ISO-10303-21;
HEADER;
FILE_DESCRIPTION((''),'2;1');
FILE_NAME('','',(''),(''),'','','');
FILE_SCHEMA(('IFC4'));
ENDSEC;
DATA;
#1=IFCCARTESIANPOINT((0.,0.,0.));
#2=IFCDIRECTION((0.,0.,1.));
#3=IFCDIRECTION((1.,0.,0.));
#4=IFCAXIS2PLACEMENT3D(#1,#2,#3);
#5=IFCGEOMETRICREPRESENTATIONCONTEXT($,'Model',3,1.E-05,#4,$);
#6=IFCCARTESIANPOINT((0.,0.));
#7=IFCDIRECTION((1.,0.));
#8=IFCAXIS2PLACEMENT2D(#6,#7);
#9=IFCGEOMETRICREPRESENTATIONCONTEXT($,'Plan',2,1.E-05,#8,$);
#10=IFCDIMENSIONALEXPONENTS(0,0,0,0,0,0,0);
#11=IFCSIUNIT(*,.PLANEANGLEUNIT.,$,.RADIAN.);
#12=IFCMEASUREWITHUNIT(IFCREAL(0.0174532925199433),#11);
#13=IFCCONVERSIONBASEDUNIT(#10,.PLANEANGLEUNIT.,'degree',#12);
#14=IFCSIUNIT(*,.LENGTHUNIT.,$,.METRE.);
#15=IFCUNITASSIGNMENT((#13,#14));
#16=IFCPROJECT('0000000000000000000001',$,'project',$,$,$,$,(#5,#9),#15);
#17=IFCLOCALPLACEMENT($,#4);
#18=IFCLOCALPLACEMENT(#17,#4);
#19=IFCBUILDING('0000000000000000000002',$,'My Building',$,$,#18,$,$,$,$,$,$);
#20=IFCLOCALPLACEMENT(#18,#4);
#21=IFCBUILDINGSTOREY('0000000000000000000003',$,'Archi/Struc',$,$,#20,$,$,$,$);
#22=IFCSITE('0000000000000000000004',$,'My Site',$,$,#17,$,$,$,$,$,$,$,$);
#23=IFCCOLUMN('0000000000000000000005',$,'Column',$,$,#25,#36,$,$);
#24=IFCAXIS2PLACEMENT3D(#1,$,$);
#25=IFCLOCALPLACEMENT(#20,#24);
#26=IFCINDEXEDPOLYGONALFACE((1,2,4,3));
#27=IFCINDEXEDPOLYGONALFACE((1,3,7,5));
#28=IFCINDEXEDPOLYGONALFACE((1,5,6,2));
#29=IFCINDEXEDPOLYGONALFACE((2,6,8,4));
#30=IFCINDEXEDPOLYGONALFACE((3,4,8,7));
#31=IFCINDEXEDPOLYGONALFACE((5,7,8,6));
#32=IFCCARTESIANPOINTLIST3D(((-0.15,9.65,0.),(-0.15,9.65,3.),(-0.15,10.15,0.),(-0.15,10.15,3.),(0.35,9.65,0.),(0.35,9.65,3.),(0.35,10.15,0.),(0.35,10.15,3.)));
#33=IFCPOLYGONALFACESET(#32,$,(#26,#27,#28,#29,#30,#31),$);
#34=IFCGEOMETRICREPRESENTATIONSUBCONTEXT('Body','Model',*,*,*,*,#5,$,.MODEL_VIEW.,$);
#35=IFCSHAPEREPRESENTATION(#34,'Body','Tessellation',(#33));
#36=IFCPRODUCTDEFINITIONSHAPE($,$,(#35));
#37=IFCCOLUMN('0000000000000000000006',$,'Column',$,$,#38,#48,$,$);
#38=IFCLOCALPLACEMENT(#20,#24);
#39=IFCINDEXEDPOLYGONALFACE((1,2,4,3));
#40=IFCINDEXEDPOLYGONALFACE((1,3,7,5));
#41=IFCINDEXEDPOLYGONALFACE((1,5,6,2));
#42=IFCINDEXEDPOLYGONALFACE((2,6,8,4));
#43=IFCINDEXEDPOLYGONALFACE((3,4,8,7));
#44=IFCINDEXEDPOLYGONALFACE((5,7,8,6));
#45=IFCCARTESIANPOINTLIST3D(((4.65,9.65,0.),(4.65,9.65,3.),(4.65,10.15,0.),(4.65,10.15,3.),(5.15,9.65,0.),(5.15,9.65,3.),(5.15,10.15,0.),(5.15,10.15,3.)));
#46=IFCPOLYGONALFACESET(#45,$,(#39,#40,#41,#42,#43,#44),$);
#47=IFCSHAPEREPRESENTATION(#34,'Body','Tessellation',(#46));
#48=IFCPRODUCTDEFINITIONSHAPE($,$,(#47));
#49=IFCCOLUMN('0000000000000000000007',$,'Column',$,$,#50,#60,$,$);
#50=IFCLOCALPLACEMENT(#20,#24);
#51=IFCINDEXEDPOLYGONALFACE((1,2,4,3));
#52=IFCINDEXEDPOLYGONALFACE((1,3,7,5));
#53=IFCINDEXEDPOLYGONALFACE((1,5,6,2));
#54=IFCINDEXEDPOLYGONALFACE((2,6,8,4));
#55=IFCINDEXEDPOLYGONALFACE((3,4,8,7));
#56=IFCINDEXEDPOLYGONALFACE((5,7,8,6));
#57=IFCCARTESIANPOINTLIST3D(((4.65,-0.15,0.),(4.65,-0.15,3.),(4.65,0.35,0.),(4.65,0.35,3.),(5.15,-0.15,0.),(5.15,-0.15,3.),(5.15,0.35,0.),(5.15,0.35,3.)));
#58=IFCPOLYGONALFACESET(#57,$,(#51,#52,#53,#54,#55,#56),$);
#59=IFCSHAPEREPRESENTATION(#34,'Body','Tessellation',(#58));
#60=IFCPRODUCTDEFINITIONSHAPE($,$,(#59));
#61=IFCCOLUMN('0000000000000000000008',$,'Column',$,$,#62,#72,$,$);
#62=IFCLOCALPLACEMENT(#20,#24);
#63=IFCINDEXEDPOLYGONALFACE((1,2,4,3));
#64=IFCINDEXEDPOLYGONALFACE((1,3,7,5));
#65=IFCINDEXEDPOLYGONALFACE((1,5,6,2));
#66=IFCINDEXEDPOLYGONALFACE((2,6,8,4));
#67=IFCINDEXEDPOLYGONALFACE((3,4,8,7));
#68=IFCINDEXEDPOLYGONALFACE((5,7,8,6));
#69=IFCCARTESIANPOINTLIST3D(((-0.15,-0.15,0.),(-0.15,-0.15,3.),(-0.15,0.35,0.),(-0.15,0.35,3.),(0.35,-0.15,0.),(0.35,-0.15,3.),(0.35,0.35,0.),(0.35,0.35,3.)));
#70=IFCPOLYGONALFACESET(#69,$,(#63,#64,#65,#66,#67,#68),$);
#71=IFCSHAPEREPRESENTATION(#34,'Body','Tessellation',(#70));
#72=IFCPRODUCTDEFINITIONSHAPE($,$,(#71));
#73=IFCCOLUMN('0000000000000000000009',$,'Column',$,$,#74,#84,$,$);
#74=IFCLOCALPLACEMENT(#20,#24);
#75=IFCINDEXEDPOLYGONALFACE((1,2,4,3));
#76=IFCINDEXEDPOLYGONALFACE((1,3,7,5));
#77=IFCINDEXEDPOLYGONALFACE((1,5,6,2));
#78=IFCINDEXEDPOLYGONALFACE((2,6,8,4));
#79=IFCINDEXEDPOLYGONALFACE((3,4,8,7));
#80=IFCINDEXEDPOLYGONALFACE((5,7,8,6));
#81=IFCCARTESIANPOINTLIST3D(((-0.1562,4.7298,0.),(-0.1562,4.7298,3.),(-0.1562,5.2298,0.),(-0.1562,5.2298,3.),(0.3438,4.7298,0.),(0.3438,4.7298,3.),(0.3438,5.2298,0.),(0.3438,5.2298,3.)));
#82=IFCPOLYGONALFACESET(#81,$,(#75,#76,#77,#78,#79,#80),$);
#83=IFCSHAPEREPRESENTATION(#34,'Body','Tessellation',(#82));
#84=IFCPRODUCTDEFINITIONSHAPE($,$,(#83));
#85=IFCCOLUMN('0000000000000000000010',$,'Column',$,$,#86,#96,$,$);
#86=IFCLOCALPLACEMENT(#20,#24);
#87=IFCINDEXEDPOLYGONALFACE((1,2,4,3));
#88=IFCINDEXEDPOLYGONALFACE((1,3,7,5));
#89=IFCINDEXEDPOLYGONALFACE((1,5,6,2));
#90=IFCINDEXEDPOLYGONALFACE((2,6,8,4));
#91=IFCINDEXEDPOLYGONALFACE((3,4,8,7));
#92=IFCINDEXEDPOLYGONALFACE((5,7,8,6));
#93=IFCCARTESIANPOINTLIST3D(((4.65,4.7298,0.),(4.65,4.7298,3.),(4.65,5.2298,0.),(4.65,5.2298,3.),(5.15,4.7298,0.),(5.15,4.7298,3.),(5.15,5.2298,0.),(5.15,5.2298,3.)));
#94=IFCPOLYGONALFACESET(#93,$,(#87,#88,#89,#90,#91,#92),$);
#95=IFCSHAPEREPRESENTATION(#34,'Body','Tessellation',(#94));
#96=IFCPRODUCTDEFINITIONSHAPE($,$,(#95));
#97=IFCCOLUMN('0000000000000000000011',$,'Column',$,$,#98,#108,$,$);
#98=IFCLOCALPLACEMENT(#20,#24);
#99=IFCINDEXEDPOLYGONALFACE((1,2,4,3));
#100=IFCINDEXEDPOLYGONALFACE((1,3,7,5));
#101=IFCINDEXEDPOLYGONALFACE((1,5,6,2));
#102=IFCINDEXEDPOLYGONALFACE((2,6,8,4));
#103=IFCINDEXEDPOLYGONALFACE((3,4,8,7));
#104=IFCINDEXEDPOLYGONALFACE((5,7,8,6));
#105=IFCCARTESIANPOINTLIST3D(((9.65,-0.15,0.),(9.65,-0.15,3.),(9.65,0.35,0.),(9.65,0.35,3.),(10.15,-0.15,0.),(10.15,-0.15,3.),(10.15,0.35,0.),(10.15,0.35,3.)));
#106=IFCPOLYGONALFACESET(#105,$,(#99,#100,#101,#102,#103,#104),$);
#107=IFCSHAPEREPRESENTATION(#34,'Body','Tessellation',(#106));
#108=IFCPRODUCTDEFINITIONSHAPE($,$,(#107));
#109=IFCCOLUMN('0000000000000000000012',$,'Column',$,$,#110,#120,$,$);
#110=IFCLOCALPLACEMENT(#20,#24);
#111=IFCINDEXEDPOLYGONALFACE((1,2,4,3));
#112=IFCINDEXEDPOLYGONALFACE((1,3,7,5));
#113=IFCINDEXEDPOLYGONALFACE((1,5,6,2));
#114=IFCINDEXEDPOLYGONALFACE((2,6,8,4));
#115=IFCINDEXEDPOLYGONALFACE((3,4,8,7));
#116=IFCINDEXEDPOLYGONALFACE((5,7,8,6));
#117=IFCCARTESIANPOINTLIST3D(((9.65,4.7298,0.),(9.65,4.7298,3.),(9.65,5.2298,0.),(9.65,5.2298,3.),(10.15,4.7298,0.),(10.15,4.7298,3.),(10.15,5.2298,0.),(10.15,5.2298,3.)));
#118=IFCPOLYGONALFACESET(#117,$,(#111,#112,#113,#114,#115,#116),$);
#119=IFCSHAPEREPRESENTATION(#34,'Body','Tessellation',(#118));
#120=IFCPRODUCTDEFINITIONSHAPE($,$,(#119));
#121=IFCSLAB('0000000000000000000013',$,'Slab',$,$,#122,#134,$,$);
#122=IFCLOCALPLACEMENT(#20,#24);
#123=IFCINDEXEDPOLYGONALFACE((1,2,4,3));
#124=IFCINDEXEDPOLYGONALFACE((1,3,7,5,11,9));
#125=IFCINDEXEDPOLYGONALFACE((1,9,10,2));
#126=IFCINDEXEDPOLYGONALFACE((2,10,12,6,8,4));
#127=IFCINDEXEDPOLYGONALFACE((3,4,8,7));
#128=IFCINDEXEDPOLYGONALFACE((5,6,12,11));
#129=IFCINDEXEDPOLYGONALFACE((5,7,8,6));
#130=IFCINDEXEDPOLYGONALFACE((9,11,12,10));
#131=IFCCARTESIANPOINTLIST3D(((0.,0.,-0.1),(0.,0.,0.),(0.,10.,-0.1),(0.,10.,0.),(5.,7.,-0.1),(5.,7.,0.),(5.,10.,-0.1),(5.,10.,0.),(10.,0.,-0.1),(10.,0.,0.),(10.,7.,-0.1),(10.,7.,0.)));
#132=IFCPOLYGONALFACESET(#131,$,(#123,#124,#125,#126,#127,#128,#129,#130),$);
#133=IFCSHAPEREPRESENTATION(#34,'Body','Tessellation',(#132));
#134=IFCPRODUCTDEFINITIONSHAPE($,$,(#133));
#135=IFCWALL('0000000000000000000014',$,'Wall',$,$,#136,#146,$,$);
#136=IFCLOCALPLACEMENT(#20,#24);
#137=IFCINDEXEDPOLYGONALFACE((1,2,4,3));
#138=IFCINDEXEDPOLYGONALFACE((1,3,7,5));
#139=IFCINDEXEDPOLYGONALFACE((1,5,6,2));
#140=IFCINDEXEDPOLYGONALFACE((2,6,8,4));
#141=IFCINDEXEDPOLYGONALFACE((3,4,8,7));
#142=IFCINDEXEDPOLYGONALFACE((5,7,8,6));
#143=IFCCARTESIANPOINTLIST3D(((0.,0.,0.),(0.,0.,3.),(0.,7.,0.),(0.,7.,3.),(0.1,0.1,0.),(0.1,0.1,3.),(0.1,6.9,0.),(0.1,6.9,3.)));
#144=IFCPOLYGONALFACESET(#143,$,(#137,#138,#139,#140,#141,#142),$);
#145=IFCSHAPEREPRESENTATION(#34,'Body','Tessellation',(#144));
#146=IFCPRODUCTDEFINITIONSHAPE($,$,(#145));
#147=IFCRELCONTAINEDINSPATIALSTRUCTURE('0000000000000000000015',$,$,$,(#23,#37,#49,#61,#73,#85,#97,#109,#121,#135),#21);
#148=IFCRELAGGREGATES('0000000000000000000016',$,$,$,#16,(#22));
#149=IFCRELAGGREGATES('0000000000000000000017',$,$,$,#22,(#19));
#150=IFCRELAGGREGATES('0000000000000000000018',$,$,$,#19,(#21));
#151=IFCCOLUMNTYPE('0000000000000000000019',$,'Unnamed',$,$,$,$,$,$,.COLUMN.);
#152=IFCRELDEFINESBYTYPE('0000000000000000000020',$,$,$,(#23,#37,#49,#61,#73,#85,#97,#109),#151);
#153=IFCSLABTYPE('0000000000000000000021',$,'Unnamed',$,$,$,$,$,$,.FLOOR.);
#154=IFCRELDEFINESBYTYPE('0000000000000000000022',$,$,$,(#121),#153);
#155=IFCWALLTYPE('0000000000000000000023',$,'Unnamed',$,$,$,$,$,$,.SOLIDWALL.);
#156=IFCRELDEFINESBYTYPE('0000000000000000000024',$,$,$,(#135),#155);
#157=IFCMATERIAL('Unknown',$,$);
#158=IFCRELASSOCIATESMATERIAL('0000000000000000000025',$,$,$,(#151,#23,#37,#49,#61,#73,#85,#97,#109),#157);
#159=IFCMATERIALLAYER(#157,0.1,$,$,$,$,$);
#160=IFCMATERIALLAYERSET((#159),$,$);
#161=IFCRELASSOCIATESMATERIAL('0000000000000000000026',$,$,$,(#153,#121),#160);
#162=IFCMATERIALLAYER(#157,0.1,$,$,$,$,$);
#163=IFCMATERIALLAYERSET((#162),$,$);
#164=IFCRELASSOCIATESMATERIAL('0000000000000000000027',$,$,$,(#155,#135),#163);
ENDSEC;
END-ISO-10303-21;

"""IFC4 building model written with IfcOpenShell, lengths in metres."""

from ifc_helpers import new_model, entity, si_unit, converted_unit, frame, origin_with_axes, origin_2d_with_axis, place, context, subcontext, project, spatial, line, indexed_curve, rectangle, outline, extrude, material, layer, layer_set, layer_usage, material_profile, profile_set, profile_usage, type_object, element, save


model = new_model("IFC4")

# Units and contexts
model_context = context("Model", 3, precision=1e-05, world=origin_with_axes())
plan_context = context("Plan", 2, precision=1e-05, world=origin_2d_with_axis())
body_context_1 = subcontext(model_context, "Body", "Model", "MODEL_VIEW")
ifc_project = project(units=[converted_unit("PLANEANGLEUNIT", "degree", entity("IfcReal", 0.0174532925199433), si_unit("PLANEANGLEUNIT", "RADIAN"), dimensions=[0, 0, 0, 0, 0, 0, 0]), si_unit("LENGTHUNIT", "METRE")], contexts=[model_context, plan_context])

# Site, building, storey
site_placement = place(None, origin_with_axes())
site = spatial("IfcSite", under=ifc_project, at=site_placement, Name="My Site")
building_placement = place(site_placement, origin_with_axes())
building = spatial("IfcBuilding", under=site, at=building_placement, Name="My Building")
storey_placement = place(building_placement, origin_with_axes())
storey = spatial("IfcBuildingStorey", under=building, at=storey_placement, Name="Archi/Struc")

# Columns
ifc_material = material(Name="Unknown")
ifc_material_profile = material_profile(ifc_material, rectangle(XDim=0.5, YDim=0.5))
ifc_profile_set = profile_set([ifc_material_profile])
ifc_profile_usage_1 = profile_usage(ifc_profile_set, cardinal=5)
column_type = type_object("IfcColumnType", Name="Unnamed", PredefinedType="COLUMN", material=ifc_profile_set)
column_1_placement = place(storey_placement, frame((0.1, 9.9, 0.0), z_axis=(0.0, 0.0, 1.0), x_axis=(1.0, 0.0, 0.0)))
element("IfcColumn", 1, at=column_1_placement, inside=storey, type_object=column_type, material=ifc_profile_usage_1, Name="Column", context=body_context_1, shape_type="SweptSolid", body=[
    extrude(rectangle(XDim=0.5, YDim=0.5), origin_with_axes(), (0.0, 0.0, 1.0), 3.0),
])
ifc_profile_usage_2 = profile_usage(ifc_profile_set, cardinal=5)
column_2_placement = place(storey_placement, frame((4.9, 9.9, 0.0), z_axis=(0.0, 0.0, 1.0), x_axis=(1.0, 0.0, 0.0)))
element("IfcColumn", 2, at=column_2_placement, inside=storey, type_object=column_type, material=ifc_profile_usage_2, Name="Column", context=body_context_1, shape_type="SweptSolid", body=[
    extrude(rectangle(XDim=0.5, YDim=0.5), origin_with_axes(), (0.0, 0.0, 1.0), 3.0),
])
ifc_profile_usage_3 = profile_usage(ifc_profile_set, cardinal=5)
column_3_placement = place(storey_placement, frame((4.9, 0.1, 0.0), z_axis=(0.0, 0.0, 1.0), x_axis=(1.0, 0.0, 0.0)))
element("IfcColumn", 3, at=column_3_placement, inside=storey, type_object=column_type, material=ifc_profile_usage_3, Name="Column", context=body_context_1, shape_type="SweptSolid", body=[
    extrude(rectangle(XDim=0.5, YDim=0.5), origin_with_axes(), (0.0, 0.0, 1.0), 3.0),
])
ifc_profile_usage_4 = profile_usage(ifc_profile_set, cardinal=5)
column_4_placement = place(storey_placement, frame((0.1, 0.1, 0.0), z_axis=(0.0, 0.0, 1.0), x_axis=(1.0, 0.0, 0.0)))
element("IfcColumn", 4, at=column_4_placement, inside=storey, type_object=column_type, material=ifc_profile_usage_4, Name="Column", context=body_context_1, shape_type="SweptSolid", body=[
    extrude(rectangle(XDim=0.5, YDim=0.5), origin_with_axes(), (0.0, 0.0, 1.0), 3.0),
])
ifc_profile_usage_5 = profile_usage(ifc_profile_set, cardinal=5)
column_5_placement = place(storey_placement, frame((0.0938, 4.9798, 0.0), z_axis=(0.0, 0.0, 1.0), x_axis=(1.0, 0.0, 0.0)))
element("IfcColumn", 5, at=column_5_placement, inside=storey, type_object=column_type, material=ifc_profile_usage_5, Name="Column", context=body_context_1, shape_type="SweptSolid", body=[
    extrude(rectangle(XDim=0.5, YDim=0.5), origin_with_axes(), (0.0, 0.0, 1.0), 3.0),
])
ifc_profile_usage_6 = profile_usage(ifc_profile_set, cardinal=5)
column_6_placement = place(storey_placement, frame((4.9, 4.9798, 0.0), z_axis=(0.0, 0.0, 1.0), x_axis=(1.0, 0.0, 0.0)))
element("IfcColumn", 6, at=column_6_placement, inside=storey, type_object=column_type, material=ifc_profile_usage_6, Name="Column", context=body_context_1, shape_type="SweptSolid", body=[
    extrude(rectangle(XDim=0.5, YDim=0.5), origin_with_axes(), (0.0, 0.0, 1.0), 3.0),
])
ifc_profile_usage_7 = profile_usage(ifc_profile_set, cardinal=5)
column_7_placement = place(storey_placement, frame((9.9, 0.1, 0.0), z_axis=(0.0, 0.0, 1.0), x_axis=(1.0, 0.0, 0.0)))
element("IfcColumn", 7, at=column_7_placement, inside=storey, type_object=column_type, material=ifc_profile_usage_7, Name="Column", context=body_context_1, shape_type="SweptSolid", body=[
    extrude(rectangle(XDim=0.5, YDim=0.5), origin_with_axes(), (0.0, 0.0, 1.0), 3.0),
])
ifc_profile_usage_8 = profile_usage(ifc_profile_set, cardinal=5)
column_8_placement = place(storey_placement, frame((9.9, 4.9798, 0.0), z_axis=(0.0, 0.0, 1.0), x_axis=(1.0, 0.0, 0.0)))
element("IfcColumn", 8, at=column_8_placement, inside=storey, type_object=column_type, material=ifc_profile_usage_8, Name="Column", context=body_context_1, shape_type="SweptSolid", body=[
    extrude(rectangle(XDim=0.5, YDim=0.5), origin_with_axes(), (0.0, 0.0, 1.0), 3.0),
])

# Slab
ifc_layer_1 = layer(ifc_material, 0.1)
ifc_layer_set_1 = layer_set([ifc_layer_1])
ifc_layer_usage_1 = layer_usage(ifc_layer_set_1, "AXIS3", "POSITIVE", -0.1)
slab_type = type_object("IfcSlabType", Name="Unnamed", PredefinedType="FLOOR", material=ifc_layer_set_1)
slab_placement = place(storey_placement, frame((0.0, 10.0, 0.0), z_axis=(0.0, 0.0, 1.0), x_axis=(1.0, 0.0, 0.0)))
element("IfcSlab", 9, at=slab_placement, inside=storey, type_object=slab_type, material=ifc_layer_usage_1, Name="Slab", context=body_context_1, shape_type="SweptSolid", body=[
    extrude(outline(indexed_curve([(0.0, 0.0), (5.0, 0.0), (5.0, -3.0), (10.0, -3.0), (10.0, -10.0), (0.0, -10.0), (0.0, 0.0)])), frame((0.0, 0.0, -0.1), z_axis=(0.0, 0.0, 1.0), x_axis=(1.0, 0.0, 0.0)), (0.0, 0.0, 1.0), 0.1),
])

# Wall
ifc_layer_2 = layer(ifc_material, 0.1)
ifc_layer_set_2 = layer_set([ifc_layer_2])
ifc_layer_usage_2 = layer_usage(ifc_layer_set_2, "AXIS2", "POSITIVE", 0.0)
wall_type = type_object("IfcWallType", Name="Unnamed", PredefinedType="SOLIDWALL", material=ifc_layer_set_2)
wall_1_placement = place(storey_placement, frame((0.0, 7.0, 0.0), z_axis=(0.0, 0.0, 1.0), x_axis=(0.0, -1.0, 0.0)))
element("IfcWall", 10, at=wall_1_placement, inside=storey, type_object=wall_type, material=ifc_layer_usage_2, Name="Wall", context=body_context_1, shape_type="SweptSolid", body=[
    extrude(outline(indexed_curve([(0.0, 0.0), (0.1, 0.1), (6.9, 0.1), (7.0, 0.0)], segments=[line(1, 2, 3, 4, 1)])), origin_with_axes(), (0.0, 0.0, 1.0), 3.0),
])

save(model, "model.ifc")
